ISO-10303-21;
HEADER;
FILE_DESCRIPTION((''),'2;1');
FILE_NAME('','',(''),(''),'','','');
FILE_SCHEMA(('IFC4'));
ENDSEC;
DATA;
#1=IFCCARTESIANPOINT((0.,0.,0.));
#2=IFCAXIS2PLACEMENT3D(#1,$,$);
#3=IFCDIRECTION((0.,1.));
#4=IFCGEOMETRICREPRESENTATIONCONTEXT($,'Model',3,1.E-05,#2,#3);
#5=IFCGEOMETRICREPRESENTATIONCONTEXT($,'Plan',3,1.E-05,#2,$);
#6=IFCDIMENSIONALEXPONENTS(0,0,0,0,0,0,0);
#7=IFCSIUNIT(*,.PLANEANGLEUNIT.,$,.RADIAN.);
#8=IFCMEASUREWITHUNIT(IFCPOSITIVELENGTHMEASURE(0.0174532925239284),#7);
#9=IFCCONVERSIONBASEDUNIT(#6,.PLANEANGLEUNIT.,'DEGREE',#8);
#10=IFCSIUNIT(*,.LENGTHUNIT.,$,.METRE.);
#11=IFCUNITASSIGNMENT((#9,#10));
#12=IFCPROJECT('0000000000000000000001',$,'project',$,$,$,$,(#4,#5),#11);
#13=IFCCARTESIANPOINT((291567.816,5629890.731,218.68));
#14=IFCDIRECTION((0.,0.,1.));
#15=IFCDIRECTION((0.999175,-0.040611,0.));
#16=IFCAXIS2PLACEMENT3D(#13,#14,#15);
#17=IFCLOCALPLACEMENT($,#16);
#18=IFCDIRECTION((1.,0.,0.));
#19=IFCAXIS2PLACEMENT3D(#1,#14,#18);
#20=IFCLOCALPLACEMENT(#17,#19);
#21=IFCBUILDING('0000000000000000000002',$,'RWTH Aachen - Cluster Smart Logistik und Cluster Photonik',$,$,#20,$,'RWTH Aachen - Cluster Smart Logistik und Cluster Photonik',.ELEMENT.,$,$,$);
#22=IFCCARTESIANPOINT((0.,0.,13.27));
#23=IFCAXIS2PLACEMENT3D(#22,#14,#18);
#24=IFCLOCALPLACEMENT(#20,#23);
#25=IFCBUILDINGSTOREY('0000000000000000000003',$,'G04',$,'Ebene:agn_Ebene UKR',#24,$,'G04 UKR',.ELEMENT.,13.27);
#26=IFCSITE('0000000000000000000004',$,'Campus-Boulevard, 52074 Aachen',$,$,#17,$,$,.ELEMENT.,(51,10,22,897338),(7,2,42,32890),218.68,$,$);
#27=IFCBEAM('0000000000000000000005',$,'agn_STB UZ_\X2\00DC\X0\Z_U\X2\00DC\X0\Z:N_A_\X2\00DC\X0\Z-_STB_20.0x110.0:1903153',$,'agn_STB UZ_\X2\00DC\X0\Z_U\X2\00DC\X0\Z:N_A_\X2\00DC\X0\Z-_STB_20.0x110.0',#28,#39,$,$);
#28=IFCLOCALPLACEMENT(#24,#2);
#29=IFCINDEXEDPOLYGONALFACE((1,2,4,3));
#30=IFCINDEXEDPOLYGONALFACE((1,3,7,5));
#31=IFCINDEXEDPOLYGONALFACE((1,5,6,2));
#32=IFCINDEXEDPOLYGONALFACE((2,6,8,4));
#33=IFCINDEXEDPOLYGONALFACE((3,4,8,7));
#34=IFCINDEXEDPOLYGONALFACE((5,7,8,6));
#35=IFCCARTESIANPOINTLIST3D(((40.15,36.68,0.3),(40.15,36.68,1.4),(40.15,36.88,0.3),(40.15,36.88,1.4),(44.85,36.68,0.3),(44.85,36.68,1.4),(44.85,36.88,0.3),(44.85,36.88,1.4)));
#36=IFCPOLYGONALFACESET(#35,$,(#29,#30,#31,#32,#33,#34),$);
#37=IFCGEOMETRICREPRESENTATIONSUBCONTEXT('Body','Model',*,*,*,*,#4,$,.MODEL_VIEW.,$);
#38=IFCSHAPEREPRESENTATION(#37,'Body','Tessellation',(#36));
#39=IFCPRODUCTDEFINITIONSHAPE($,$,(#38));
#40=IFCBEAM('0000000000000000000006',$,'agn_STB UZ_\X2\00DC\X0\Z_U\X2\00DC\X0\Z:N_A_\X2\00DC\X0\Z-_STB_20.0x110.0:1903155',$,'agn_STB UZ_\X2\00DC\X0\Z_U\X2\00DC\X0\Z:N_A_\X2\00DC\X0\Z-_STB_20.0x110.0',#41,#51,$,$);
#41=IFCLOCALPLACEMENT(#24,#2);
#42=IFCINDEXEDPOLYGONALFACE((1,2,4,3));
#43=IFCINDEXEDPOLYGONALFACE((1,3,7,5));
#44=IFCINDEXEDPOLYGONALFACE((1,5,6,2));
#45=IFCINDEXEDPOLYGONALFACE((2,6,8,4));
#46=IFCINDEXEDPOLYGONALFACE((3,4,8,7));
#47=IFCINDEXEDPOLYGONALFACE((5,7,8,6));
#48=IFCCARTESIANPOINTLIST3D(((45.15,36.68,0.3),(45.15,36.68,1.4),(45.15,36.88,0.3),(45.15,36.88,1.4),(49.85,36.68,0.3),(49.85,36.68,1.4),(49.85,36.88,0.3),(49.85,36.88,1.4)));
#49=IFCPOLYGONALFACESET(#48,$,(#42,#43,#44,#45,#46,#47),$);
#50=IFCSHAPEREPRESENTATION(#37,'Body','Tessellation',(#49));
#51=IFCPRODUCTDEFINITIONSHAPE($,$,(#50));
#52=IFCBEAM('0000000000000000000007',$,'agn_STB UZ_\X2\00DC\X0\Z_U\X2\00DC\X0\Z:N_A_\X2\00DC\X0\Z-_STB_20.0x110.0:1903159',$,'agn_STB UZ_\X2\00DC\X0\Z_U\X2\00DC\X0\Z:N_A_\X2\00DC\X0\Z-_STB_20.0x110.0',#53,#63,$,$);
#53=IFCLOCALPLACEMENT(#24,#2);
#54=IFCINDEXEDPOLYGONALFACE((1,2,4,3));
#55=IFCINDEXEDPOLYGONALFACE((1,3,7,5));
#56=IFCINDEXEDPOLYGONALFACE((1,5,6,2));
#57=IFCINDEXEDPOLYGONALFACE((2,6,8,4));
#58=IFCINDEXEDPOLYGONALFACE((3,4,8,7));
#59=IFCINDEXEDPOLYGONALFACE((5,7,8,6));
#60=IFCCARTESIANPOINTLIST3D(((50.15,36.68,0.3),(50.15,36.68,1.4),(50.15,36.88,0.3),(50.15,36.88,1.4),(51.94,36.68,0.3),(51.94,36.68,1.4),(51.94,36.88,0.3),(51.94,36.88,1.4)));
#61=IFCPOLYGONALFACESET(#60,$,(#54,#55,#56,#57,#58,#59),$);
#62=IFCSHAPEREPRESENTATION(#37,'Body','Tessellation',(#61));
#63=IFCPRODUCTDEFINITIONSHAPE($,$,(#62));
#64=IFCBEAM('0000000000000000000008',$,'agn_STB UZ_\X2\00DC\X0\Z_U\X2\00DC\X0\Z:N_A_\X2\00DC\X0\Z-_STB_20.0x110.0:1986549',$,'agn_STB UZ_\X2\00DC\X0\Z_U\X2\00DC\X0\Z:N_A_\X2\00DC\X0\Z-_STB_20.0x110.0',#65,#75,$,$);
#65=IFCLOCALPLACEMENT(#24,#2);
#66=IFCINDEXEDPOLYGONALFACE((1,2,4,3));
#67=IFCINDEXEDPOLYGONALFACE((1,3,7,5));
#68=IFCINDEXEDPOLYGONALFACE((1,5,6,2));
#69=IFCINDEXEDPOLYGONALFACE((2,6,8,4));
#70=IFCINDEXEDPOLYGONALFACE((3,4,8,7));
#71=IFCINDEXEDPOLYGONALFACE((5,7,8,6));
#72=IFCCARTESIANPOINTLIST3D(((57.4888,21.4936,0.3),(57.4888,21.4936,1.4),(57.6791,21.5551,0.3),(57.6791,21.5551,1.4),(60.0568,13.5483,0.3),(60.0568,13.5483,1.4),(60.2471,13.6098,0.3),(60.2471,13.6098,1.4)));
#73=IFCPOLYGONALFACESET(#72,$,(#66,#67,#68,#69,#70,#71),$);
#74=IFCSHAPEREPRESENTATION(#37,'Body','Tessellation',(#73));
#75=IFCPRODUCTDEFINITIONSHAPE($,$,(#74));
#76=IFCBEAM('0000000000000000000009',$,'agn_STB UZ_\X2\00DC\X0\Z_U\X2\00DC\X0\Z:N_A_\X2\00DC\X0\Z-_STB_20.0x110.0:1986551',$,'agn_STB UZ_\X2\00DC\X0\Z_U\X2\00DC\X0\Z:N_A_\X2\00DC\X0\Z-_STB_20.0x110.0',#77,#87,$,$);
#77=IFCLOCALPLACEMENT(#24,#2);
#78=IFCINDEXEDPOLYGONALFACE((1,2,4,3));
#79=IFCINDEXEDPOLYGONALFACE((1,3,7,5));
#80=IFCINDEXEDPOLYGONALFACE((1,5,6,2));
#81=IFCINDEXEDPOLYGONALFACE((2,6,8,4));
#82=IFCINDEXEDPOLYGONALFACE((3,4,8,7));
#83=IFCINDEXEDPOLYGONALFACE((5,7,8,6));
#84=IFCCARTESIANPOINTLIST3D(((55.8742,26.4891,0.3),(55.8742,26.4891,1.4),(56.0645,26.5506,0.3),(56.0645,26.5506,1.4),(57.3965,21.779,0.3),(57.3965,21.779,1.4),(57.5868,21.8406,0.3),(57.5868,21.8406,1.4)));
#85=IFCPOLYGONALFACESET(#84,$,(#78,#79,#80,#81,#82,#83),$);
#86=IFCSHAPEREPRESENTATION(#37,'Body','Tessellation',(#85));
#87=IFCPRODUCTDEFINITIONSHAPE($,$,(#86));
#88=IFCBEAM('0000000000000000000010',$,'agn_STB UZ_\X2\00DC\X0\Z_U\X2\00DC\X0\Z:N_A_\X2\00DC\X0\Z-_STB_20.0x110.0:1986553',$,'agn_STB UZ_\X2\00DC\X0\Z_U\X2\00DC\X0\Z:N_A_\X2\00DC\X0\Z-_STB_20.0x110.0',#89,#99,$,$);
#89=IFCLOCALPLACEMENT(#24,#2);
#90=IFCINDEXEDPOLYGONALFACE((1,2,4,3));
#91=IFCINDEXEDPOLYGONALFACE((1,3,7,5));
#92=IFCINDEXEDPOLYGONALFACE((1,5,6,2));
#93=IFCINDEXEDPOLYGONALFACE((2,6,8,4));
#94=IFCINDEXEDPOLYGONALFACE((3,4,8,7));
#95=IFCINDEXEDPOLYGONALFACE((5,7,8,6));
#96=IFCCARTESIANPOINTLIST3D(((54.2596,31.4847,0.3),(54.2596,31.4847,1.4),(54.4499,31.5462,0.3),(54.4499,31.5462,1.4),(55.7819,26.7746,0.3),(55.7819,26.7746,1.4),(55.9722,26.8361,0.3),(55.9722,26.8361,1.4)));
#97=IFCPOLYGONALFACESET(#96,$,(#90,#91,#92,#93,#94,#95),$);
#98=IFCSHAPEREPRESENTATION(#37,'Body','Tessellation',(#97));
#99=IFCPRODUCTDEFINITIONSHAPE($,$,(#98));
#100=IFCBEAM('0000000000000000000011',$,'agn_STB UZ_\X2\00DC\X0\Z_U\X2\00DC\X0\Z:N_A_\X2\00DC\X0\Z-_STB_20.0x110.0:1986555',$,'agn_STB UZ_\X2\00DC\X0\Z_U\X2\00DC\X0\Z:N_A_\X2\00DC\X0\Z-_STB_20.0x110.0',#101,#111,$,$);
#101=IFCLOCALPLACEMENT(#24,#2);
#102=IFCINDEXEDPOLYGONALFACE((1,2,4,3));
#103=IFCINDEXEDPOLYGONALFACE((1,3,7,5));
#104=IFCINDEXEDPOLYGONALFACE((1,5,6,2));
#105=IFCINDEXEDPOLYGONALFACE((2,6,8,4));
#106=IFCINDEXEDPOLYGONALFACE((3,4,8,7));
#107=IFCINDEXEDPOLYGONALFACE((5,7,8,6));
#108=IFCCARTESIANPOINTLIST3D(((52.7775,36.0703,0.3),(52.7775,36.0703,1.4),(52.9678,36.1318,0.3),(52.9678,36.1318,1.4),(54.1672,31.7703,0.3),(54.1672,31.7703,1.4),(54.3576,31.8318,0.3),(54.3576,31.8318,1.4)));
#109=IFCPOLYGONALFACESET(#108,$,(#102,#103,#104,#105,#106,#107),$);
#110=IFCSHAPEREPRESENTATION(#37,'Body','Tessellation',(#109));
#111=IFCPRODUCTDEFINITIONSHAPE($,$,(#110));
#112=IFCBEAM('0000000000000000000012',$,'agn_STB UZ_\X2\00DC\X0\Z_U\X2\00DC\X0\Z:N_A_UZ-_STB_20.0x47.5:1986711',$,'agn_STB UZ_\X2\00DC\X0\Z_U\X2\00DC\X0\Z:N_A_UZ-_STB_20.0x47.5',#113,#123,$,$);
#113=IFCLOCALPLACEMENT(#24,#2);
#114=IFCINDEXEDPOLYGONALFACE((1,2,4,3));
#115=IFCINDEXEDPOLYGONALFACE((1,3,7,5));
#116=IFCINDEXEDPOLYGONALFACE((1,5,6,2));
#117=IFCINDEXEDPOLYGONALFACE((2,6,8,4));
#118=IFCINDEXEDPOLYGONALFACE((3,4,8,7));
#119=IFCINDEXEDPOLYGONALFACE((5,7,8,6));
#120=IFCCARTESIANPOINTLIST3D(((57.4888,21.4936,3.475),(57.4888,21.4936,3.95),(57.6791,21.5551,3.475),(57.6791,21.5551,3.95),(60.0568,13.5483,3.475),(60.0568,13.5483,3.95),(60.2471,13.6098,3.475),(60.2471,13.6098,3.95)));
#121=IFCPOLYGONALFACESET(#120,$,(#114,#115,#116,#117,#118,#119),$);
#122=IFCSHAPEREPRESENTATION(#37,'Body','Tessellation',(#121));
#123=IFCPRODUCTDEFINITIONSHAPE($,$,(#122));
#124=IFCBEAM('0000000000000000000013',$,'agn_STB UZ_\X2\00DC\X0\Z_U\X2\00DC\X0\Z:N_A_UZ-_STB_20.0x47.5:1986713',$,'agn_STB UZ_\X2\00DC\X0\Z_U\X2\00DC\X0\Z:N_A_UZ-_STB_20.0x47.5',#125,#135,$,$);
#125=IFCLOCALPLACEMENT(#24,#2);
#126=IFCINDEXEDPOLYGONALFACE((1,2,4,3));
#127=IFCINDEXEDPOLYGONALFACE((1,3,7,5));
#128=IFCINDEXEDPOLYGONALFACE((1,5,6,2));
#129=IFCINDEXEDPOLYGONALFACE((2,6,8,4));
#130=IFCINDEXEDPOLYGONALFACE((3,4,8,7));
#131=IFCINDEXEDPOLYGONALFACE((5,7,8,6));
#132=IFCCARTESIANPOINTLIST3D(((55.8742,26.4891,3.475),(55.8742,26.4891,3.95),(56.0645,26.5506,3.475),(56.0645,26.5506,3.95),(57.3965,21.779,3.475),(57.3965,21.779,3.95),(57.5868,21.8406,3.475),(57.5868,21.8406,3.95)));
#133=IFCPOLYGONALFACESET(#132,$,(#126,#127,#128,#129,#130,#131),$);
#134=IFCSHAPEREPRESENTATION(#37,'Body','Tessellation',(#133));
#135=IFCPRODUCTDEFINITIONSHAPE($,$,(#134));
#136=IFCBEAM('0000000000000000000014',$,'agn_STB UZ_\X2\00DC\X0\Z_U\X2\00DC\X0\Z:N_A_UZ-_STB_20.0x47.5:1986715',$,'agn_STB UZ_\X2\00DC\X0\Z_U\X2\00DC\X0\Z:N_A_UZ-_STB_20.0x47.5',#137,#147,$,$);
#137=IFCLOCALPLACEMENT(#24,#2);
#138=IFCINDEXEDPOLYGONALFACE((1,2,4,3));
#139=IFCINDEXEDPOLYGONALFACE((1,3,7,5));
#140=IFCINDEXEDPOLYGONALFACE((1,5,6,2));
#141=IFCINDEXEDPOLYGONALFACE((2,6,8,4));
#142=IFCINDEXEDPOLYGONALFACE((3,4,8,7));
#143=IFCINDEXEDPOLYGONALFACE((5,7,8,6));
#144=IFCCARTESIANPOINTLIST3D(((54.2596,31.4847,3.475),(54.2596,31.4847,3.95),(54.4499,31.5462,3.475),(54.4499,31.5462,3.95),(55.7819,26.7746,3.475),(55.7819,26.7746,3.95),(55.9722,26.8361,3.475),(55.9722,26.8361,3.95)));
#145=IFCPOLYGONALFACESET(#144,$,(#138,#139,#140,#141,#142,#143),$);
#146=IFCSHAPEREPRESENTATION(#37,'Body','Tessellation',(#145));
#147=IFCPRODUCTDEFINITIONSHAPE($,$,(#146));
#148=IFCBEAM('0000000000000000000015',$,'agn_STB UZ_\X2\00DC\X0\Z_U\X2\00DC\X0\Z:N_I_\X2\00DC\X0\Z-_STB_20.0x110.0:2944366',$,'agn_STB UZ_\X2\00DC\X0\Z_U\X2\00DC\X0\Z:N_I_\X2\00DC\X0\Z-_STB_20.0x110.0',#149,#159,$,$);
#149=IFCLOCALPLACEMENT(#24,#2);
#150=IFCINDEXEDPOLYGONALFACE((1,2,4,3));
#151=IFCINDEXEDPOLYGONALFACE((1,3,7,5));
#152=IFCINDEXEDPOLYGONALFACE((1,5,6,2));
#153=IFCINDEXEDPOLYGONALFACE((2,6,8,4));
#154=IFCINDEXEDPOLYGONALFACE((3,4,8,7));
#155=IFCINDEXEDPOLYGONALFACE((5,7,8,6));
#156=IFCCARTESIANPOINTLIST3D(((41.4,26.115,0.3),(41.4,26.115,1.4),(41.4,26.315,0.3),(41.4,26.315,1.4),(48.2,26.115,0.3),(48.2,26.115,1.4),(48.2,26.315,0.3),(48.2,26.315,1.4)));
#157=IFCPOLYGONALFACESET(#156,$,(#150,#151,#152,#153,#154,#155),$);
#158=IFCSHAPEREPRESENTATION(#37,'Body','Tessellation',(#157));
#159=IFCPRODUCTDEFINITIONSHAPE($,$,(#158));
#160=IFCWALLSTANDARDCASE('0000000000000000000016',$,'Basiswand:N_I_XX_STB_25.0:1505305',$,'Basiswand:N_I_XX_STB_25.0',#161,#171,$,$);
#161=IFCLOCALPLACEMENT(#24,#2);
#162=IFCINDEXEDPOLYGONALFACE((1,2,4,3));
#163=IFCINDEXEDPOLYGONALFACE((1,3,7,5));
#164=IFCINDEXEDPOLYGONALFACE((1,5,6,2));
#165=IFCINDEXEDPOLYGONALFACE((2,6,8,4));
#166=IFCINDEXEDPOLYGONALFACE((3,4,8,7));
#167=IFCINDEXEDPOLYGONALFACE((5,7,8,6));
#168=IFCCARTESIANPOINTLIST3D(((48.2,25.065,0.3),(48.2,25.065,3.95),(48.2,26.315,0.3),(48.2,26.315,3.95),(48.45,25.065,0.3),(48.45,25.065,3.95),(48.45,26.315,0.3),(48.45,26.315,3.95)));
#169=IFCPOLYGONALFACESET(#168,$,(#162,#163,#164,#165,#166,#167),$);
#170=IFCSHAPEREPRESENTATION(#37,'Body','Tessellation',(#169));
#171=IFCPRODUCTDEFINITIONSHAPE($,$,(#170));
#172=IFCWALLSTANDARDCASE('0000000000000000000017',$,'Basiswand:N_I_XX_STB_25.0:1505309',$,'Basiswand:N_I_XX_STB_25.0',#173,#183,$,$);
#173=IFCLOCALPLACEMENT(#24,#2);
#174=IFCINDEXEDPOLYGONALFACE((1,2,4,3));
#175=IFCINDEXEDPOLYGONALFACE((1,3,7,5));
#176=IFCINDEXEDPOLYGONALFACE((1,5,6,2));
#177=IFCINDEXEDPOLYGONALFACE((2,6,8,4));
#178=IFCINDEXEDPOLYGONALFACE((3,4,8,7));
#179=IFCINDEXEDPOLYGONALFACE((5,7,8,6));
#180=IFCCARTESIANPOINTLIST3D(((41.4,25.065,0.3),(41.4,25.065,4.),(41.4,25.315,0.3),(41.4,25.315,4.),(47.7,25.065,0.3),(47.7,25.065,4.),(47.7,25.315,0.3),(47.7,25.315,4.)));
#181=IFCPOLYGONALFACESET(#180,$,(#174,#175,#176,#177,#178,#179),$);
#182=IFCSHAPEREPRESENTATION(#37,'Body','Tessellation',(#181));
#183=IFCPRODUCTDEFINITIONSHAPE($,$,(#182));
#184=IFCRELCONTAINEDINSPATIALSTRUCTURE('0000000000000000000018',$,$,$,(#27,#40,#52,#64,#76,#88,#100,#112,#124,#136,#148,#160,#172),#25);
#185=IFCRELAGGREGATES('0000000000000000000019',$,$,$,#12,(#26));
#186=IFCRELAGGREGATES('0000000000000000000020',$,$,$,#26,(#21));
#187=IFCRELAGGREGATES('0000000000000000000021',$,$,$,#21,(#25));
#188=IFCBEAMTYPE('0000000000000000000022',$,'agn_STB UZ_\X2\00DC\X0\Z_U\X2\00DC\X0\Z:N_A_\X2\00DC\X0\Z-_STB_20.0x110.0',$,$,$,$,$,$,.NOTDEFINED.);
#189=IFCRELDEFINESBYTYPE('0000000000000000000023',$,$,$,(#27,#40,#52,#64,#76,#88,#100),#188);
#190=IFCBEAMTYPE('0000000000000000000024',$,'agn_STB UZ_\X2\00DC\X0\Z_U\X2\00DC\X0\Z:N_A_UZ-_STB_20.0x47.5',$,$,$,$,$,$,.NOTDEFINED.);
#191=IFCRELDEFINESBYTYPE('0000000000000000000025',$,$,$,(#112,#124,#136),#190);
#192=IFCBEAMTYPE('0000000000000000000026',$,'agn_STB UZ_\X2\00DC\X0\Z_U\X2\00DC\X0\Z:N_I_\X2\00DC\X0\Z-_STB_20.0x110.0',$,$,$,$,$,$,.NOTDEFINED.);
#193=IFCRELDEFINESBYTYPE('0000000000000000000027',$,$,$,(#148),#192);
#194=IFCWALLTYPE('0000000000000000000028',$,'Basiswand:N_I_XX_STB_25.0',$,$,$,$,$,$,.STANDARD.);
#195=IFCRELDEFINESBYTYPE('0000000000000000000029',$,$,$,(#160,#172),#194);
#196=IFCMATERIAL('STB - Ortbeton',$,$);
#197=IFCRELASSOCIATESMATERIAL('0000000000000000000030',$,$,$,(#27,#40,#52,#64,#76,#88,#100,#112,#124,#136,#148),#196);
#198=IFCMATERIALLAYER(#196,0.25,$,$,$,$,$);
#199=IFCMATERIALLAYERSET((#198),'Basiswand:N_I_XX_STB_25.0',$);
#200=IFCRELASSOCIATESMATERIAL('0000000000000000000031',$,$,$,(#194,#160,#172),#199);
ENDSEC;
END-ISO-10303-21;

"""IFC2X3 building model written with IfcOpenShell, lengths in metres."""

from ifc_helpers import new_model, entity, si_unit, converted_unit, direction, frame, frame_2d, origin, origin_with_axes, place, context, subcontext, project, spatial, rectangle, extrude, material, layer, layer_set, layer_usage, type_object, element, save


model = new_model("IFC2X3")

# Units and contexts
model_context = context("Model", 3, precision=1e-05, world=origin(), true_north=direction((0.0, 1.0)))
plan_context = context("Plan", 3, precision=1e-05, world=origin())
body_context = subcontext(model_context, "Body", "Model", "MODEL_VIEW")
ifc_project = project(units=[converted_unit("PLANEANGLEUNIT", "DEGREE", entity("IfcPositiveLengthMeasure", 0.0174532925239284), si_unit("PLANEANGLEUNIT", "RADIAN"), dimensions=[0, 0, 0, 0, 0, 0, 0]), si_unit("LENGTHUNIT", "METRE")], contexts=[model_context, plan_context])

# Site, building, storey
site_placement = place(None, frame((291567.816, 5629890.731, 218.68), z_axis=(0.0, 0.0, 1.0), x_axis=(0.999175, -0.040611, 0.0)))
site = spatial("IfcSite", under=ifc_project, at=site_placement, Name="Campus-Boulevard, 52074 Aachen", CompositionType="ELEMENT", RefLatitude=(51, 10, 22, 897338), RefLongitude=(7, 2, 42, 32890), RefElevation=218.68)
building_placement = place(site_placement, origin_with_axes())
building = spatial("IfcBuilding", under=site, at=building_placement, Name="RWTH Aachen - Cluster Smart Logistik und Cluster Photonik", LongName="RWTH Aachen - Cluster Smart Logistik und Cluster Photonik", CompositionType="ELEMENT")
storey_placement = place(building_placement, frame((0.0, 0.0, 13.27), z_axis=(0.0, 0.0, 1.0), x_axis=(1.0, 0.0, 0.0)))
storey = spatial("IfcBuildingStorey", under=building, at=storey_placement, Name="G04", ObjectType="Ebene:agn_Ebene UKR", LongName="G04 UKR", CompositionType="ELEMENT", Elevation=13.27)

# Beams
ifc_material_1 = material(Name="STB - Ortbeton")
beam_type_1 = type_object("IfcBeamType", Name="agn_STB UZ_ÜZ_UÜZ:N_A_ÜZ-_STB_20.0x110.0", PredefinedType="NOTDEFINED")
for number, where, z_axis, x_axis, name in (
    (1, (40.15, 36.78, 0.3), (0.0, 0.0, 1.0), (1.0, 0.0, 0.0), "agn_STB UZ_ÜZ_UÜZ:N_A_ÜZ-_STB_20.0x110.0:1903153"),
    (2, (45.15, 36.78, 0.3), (0.0, 0.0, 1.0), (1.0, 0.0, 0.0), "agn_STB UZ_ÜZ_UÜZ:N_A_ÜZ-_STB_20.0x110.0:1903155"),
):
    element("IfcBeam", number, at=place(storey_placement, frame(where, z_axis=z_axis, x_axis=x_axis)), inside=storey, type_object=beam_type_1, material=ifc_material_1, Name=name, ObjectType="agn_STB UZ_ÜZ_UÜZ:N_A_ÜZ-_STB_20.0x110.0", context=body_context, shape_type="SweptSolid", body=[
        extrude(rectangle(XDim=1.1, YDim=0.2, at=frame_2d((0.0, 0.0), x_axis=(1.0, 0.0))), frame((0.0, 0.0, 0.55), z_axis=(1.0, 0.0, 0.0), x_axis=(0.0, 0.0, -1.0)), (0.0, 0.0, 1.0), 4.7),
    ])
beam_1_placement = place(storey_placement, frame((50.15, 36.78, 0.3), z_axis=(0.0, 0.0, 1.0), x_axis=(1.0, 0.0, 0.0)))
element("IfcBeam", 3, at=beam_1_placement, inside=storey, type_object=beam_type_1, material=ifc_material_1, Name="agn_STB UZ_ÜZ_UÜZ:N_A_ÜZ-_STB_20.0x110.0:1903159", ObjectType="agn_STB UZ_ÜZ_UÜZ:N_A_ÜZ-_STB_20.0x110.0", context=body_context, shape_type="SweptSolid", body=[
    extrude(rectangle(XDim=1.1, YDim=0.2, at=frame_2d((0.0, 0.0), x_axis=(1.0, 0.0))), frame((0.0, 0.0, 0.55), z_axis=(1.0, 0.0, 0.0), x_axis=(0.0, 0.0, -1.0)), (0.0, 0.0, 1.0), 1.79),
])
beam_2_placement = place(storey_placement, frame((57.5839, 21.5245, 0.3), z_axis=(0.0, 0.0, 1.0), x_axis=(0.307544, -0.951534, 0.0)))
element("IfcBeam", 4, at=beam_2_placement, inside=storey, type_object=beam_type_1, material=ifc_material_1, Name="agn_STB UZ_ÜZ_UÜZ:N_A_ÜZ-_STB_20.0x110.0:1986549", ObjectType="agn_STB UZ_ÜZ_UÜZ:N_A_ÜZ-_STB_20.0x110.0", context=body_context, shape_type="SweptSolid", body=[
    extrude(rectangle(XDim=1.1, YDim=0.2, at=frame_2d((0.0, 0.0), x_axis=(1.0, 0.0))), frame((0.0002, 0.0, 0.55), z_axis=(1.0, 0.0, 0.0), x_axis=(0.0, 0.0, -1.0)), (0.0, 0.0, 1.0), 8.35),
])
beam_3_placement = place(storey_placement, frame((55.9693, 26.52, 0.3), z_axis=(0.0, 0.0, 1.0), x_axis=(0.307544, -0.951534, 0.0)))
element("IfcBeam", 5, at=beam_3_placement, inside=storey, type_object=beam_type_1, material=ifc_material_1, Name="agn_STB UZ_ÜZ_UÜZ:N_A_ÜZ-_STB_20.0x110.0:1986551", ObjectType="agn_STB UZ_ÜZ_UÜZ:N_A_ÜZ-_STB_20.0x110.0", context=body_context, shape_type="SweptSolid", body=[
    extrude(rectangle(XDim=1.1, YDim=0.2, at=frame_2d((0.0, 0.0), x_axis=(1.0, 0.0))), frame((0.0002, 0.0, 0.55), z_axis=(1.0, 0.0, 0.0), x_axis=(0.0, 0.0, -1.0)), (0.0, 0.0, 1.0), 4.95),
])
beam_4_placement = place(storey_placement, frame((54.3547, 31.5156, 0.3), z_axis=(0.0, 0.0, 1.0), x_axis=(0.307544, -0.951534, 0.0)))
element("IfcBeam", 6, at=beam_4_placement, inside=storey, type_object=beam_type_1, material=ifc_material_1, Name="agn_STB UZ_ÜZ_UÜZ:N_A_ÜZ-_STB_20.0x110.0:1986553", ObjectType="agn_STB UZ_ÜZ_UÜZ:N_A_ÜZ-_STB_20.0x110.0", context=body_context, shape_type="SweptSolid", body=[
    extrude(rectangle(XDim=1.1, YDim=0.2, at=frame_2d((0.0, 0.0), x_axis=(1.0, 0.0))), frame((0.0002, 0.0, 0.55), z_axis=(1.0, 0.0, 0.0), x_axis=(0.0, 0.0, -1.0)), (0.0, 0.0, 1.0), 4.95),
])
beam_5_placement = place(storey_placement, frame((52.8725, 36.1014, 0.3), z_axis=(0.0, 0.0, 1.0), x_axis=(0.307544, -0.951534, 0.0)))
element("IfcBeam", 7, at=beam_5_placement, inside=storey, type_object=beam_type_1, material=ifc_material_1, Name="agn_STB UZ_ÜZ_UÜZ:N_A_ÜZ-_STB_20.0x110.0:1986555", ObjectType="agn_STB UZ_ÜZ_UÜZ:N_A_ÜZ-_STB_20.0x110.0", context=body_context, shape_type="SweptSolid", body=[
    extrude(rectangle(XDim=1.1, YDim=0.2, at=frame_2d((0.0, 0.0), x_axis=(1.0, 0.0))), frame((0.0003, 0.0, 0.55), z_axis=(1.0, 0.0, 0.0), x_axis=(0.0, 0.0, -1.0)), (0.0, 0.0, 1.0), 4.519),
])
beam_type_2 = type_object("IfcBeamType", Name="agn_STB UZ_ÜZ_UÜZ:N_A_UZ-_STB_20.0x47.5", PredefinedType="NOTDEFINED")
beam_6_placement = place(storey_placement, frame((57.5839, 21.5245, 0.3), z_axis=(0.0, 0.0, 1.0), x_axis=(0.307544, -0.951534, 0.0)))
element("IfcBeam", 8, at=beam_6_placement, inside=storey, type_object=beam_type_2, material=ifc_material_1, Name="agn_STB UZ_ÜZ_UÜZ:N_A_UZ-_STB_20.0x47.5:1986711", ObjectType="agn_STB UZ_ÜZ_UÜZ:N_A_UZ-_STB_20.0x47.5", context=body_context, shape_type="SweptSolid", body=[
    extrude(rectangle(XDim=0.475, YDim=0.2, at=frame_2d((0.0, 0.0), x_axis=(1.0, 0.0))), frame((0.0002, 0.0, 3.4125), z_axis=(1.0, 0.0, 0.0), x_axis=(0.0, 0.0, -1.0)), (0.0, 0.0, 1.0), 8.35),
])
beam_7_placement = place(storey_placement, frame((55.9693, 26.52, 0.3), z_axis=(0.0, 0.0, 1.0), x_axis=(0.307544, -0.951534, 0.0)))
element("IfcBeam", 9, at=beam_7_placement, inside=storey, type_object=beam_type_2, material=ifc_material_1, Name="agn_STB UZ_ÜZ_UÜZ:N_A_UZ-_STB_20.0x47.5:1986713", ObjectType="agn_STB UZ_ÜZ_UÜZ:N_A_UZ-_STB_20.0x47.5", context=body_context, shape_type="SweptSolid", body=[
    extrude(rectangle(XDim=0.475, YDim=0.2, at=frame_2d((0.0, 0.0), x_axis=(1.0, 0.0))), frame((0.0002, 0.0, 3.4125), z_axis=(1.0, 0.0, 0.0), x_axis=(0.0, 0.0, -1.0)), (0.0, 0.0, 1.0), 4.95),
])
beam_8_placement = place(storey_placement, frame((54.3547, 31.5156, 0.3), z_axis=(0.0, 0.0, 1.0), x_axis=(0.307544, -0.951534, 0.0)))
element("IfcBeam", 10, at=beam_8_placement, inside=storey, type_object=beam_type_2, material=ifc_material_1, Name="agn_STB UZ_ÜZ_UÜZ:N_A_UZ-_STB_20.0x47.5:1986715", ObjectType="agn_STB UZ_ÜZ_UÜZ:N_A_UZ-_STB_20.0x47.5", context=body_context, shape_type="SweptSolid", body=[
    extrude(rectangle(XDim=0.475, YDim=0.2, at=frame_2d((0.0, 0.0), x_axis=(1.0, 0.0))), frame((0.0002, 0.0, 3.4125), z_axis=(1.0, 0.0, 0.0), x_axis=(0.0, 0.0, -1.0)), (0.0, 0.0, 1.0), 4.95),
])
beam_type_3 = type_object("IfcBeamType", Name="agn_STB UZ_ÜZ_UÜZ:N_I_ÜZ-_STB_20.0x110.0", PredefinedType="NOTDEFINED")
beam_9_placement = place(storey_placement, frame((48.325, 26.215, 0.3), z_axis=(0.0, 0.0, 1.0), x_axis=(-1.0, 0.0, 0.0)))
element("IfcBeam", 11, at=beam_9_placement, inside=storey, type_object=beam_type_3, material=ifc_material_1, Name="agn_STB UZ_ÜZ_UÜZ:N_I_ÜZ-_STB_20.0x110.0:2944366", ObjectType="agn_STB UZ_ÜZ_UÜZ:N_I_ÜZ-_STB_20.0x110.0", context=body_context, shape_type="SweptSolid", body=[
    extrude(rectangle(XDim=1.1, YDim=0.2, at=frame_2d((0.0, 0.0), x_axis=(1.0, 0.0))), frame((0.125, 0.0, 0.55), z_axis=(1.0, 0.0, 0.0), x_axis=(0.0, 0.0, -1.0)), (0.0, 0.0, 1.0), 6.8),
])

# Walls
ifc_layer_1 = layer(ifc_material_1, 0.25)
ifc_layer_set_1 = layer_set([ifc_layer_1], Name="Basiswand:N_I_XX_STB_25.0")
ifc_layer_usage_1 = layer_usage(ifc_layer_set_1, "AXIS2", "NEGATIVE", 0.125)
wall_type_1 = type_object("IfcWallType", Name="Basiswand:N_I_XX_STB_25.0", PredefinedType="STANDARD", material=ifc_layer_set_1)
wall_1_placement = place(storey_placement, frame((48.325, 25.065, 0.3), z_axis=(0.0, 0.0, 1.0), x_axis=(0.0, 1.0, 0.0)))
element("IfcWallStandardCase", 12, at=wall_1_placement, inside=storey, type_object=wall_type_1, material=ifc_layer_usage_1, Name="Basiswand:N_I_XX_STB_25.0:1505305", ObjectType="Basiswand:N_I_XX_STB_25.0", context=body_context, shape_type="SweptSolid", body=[
    extrude(rectangle(XDim=1.25, YDim=0.25, at=frame_2d((0.625, 0.0), x_axis=(-1.0, 0.0))), origin(), (0.0, 0.0, 1.0), 3.65),
])
ifc_layer_usage_2 = layer_usage(ifc_layer_set_1, "AXIS2", "NEGATIVE", 0.125)
wall_2_placement = place(storey_placement, frame((41.4, 25.19, 0.3), z_axis=(0.0, 0.0, 1.0), x_axis=(1.0, 0.0, 0.0)))
element("IfcWallStandardCase", 13, at=wall_2_placement, inside=storey, type_object=wall_type_1, material=ifc_layer_usage_2, Name="Basiswand:N_I_XX_STB_25.0:1505309", ObjectType="Basiswand:N_I_XX_STB_25.0", context=body_context, shape_type="SweptSolid", body=[
    extrude(rectangle(XDim=6.3, YDim=0.25, at=frame_2d((3.15, 0.0), x_axis=(-1.0, 0.0))), origin(), (0.0, 0.0, 1.0), 3.7),
])

save(model, "model.ifc")
